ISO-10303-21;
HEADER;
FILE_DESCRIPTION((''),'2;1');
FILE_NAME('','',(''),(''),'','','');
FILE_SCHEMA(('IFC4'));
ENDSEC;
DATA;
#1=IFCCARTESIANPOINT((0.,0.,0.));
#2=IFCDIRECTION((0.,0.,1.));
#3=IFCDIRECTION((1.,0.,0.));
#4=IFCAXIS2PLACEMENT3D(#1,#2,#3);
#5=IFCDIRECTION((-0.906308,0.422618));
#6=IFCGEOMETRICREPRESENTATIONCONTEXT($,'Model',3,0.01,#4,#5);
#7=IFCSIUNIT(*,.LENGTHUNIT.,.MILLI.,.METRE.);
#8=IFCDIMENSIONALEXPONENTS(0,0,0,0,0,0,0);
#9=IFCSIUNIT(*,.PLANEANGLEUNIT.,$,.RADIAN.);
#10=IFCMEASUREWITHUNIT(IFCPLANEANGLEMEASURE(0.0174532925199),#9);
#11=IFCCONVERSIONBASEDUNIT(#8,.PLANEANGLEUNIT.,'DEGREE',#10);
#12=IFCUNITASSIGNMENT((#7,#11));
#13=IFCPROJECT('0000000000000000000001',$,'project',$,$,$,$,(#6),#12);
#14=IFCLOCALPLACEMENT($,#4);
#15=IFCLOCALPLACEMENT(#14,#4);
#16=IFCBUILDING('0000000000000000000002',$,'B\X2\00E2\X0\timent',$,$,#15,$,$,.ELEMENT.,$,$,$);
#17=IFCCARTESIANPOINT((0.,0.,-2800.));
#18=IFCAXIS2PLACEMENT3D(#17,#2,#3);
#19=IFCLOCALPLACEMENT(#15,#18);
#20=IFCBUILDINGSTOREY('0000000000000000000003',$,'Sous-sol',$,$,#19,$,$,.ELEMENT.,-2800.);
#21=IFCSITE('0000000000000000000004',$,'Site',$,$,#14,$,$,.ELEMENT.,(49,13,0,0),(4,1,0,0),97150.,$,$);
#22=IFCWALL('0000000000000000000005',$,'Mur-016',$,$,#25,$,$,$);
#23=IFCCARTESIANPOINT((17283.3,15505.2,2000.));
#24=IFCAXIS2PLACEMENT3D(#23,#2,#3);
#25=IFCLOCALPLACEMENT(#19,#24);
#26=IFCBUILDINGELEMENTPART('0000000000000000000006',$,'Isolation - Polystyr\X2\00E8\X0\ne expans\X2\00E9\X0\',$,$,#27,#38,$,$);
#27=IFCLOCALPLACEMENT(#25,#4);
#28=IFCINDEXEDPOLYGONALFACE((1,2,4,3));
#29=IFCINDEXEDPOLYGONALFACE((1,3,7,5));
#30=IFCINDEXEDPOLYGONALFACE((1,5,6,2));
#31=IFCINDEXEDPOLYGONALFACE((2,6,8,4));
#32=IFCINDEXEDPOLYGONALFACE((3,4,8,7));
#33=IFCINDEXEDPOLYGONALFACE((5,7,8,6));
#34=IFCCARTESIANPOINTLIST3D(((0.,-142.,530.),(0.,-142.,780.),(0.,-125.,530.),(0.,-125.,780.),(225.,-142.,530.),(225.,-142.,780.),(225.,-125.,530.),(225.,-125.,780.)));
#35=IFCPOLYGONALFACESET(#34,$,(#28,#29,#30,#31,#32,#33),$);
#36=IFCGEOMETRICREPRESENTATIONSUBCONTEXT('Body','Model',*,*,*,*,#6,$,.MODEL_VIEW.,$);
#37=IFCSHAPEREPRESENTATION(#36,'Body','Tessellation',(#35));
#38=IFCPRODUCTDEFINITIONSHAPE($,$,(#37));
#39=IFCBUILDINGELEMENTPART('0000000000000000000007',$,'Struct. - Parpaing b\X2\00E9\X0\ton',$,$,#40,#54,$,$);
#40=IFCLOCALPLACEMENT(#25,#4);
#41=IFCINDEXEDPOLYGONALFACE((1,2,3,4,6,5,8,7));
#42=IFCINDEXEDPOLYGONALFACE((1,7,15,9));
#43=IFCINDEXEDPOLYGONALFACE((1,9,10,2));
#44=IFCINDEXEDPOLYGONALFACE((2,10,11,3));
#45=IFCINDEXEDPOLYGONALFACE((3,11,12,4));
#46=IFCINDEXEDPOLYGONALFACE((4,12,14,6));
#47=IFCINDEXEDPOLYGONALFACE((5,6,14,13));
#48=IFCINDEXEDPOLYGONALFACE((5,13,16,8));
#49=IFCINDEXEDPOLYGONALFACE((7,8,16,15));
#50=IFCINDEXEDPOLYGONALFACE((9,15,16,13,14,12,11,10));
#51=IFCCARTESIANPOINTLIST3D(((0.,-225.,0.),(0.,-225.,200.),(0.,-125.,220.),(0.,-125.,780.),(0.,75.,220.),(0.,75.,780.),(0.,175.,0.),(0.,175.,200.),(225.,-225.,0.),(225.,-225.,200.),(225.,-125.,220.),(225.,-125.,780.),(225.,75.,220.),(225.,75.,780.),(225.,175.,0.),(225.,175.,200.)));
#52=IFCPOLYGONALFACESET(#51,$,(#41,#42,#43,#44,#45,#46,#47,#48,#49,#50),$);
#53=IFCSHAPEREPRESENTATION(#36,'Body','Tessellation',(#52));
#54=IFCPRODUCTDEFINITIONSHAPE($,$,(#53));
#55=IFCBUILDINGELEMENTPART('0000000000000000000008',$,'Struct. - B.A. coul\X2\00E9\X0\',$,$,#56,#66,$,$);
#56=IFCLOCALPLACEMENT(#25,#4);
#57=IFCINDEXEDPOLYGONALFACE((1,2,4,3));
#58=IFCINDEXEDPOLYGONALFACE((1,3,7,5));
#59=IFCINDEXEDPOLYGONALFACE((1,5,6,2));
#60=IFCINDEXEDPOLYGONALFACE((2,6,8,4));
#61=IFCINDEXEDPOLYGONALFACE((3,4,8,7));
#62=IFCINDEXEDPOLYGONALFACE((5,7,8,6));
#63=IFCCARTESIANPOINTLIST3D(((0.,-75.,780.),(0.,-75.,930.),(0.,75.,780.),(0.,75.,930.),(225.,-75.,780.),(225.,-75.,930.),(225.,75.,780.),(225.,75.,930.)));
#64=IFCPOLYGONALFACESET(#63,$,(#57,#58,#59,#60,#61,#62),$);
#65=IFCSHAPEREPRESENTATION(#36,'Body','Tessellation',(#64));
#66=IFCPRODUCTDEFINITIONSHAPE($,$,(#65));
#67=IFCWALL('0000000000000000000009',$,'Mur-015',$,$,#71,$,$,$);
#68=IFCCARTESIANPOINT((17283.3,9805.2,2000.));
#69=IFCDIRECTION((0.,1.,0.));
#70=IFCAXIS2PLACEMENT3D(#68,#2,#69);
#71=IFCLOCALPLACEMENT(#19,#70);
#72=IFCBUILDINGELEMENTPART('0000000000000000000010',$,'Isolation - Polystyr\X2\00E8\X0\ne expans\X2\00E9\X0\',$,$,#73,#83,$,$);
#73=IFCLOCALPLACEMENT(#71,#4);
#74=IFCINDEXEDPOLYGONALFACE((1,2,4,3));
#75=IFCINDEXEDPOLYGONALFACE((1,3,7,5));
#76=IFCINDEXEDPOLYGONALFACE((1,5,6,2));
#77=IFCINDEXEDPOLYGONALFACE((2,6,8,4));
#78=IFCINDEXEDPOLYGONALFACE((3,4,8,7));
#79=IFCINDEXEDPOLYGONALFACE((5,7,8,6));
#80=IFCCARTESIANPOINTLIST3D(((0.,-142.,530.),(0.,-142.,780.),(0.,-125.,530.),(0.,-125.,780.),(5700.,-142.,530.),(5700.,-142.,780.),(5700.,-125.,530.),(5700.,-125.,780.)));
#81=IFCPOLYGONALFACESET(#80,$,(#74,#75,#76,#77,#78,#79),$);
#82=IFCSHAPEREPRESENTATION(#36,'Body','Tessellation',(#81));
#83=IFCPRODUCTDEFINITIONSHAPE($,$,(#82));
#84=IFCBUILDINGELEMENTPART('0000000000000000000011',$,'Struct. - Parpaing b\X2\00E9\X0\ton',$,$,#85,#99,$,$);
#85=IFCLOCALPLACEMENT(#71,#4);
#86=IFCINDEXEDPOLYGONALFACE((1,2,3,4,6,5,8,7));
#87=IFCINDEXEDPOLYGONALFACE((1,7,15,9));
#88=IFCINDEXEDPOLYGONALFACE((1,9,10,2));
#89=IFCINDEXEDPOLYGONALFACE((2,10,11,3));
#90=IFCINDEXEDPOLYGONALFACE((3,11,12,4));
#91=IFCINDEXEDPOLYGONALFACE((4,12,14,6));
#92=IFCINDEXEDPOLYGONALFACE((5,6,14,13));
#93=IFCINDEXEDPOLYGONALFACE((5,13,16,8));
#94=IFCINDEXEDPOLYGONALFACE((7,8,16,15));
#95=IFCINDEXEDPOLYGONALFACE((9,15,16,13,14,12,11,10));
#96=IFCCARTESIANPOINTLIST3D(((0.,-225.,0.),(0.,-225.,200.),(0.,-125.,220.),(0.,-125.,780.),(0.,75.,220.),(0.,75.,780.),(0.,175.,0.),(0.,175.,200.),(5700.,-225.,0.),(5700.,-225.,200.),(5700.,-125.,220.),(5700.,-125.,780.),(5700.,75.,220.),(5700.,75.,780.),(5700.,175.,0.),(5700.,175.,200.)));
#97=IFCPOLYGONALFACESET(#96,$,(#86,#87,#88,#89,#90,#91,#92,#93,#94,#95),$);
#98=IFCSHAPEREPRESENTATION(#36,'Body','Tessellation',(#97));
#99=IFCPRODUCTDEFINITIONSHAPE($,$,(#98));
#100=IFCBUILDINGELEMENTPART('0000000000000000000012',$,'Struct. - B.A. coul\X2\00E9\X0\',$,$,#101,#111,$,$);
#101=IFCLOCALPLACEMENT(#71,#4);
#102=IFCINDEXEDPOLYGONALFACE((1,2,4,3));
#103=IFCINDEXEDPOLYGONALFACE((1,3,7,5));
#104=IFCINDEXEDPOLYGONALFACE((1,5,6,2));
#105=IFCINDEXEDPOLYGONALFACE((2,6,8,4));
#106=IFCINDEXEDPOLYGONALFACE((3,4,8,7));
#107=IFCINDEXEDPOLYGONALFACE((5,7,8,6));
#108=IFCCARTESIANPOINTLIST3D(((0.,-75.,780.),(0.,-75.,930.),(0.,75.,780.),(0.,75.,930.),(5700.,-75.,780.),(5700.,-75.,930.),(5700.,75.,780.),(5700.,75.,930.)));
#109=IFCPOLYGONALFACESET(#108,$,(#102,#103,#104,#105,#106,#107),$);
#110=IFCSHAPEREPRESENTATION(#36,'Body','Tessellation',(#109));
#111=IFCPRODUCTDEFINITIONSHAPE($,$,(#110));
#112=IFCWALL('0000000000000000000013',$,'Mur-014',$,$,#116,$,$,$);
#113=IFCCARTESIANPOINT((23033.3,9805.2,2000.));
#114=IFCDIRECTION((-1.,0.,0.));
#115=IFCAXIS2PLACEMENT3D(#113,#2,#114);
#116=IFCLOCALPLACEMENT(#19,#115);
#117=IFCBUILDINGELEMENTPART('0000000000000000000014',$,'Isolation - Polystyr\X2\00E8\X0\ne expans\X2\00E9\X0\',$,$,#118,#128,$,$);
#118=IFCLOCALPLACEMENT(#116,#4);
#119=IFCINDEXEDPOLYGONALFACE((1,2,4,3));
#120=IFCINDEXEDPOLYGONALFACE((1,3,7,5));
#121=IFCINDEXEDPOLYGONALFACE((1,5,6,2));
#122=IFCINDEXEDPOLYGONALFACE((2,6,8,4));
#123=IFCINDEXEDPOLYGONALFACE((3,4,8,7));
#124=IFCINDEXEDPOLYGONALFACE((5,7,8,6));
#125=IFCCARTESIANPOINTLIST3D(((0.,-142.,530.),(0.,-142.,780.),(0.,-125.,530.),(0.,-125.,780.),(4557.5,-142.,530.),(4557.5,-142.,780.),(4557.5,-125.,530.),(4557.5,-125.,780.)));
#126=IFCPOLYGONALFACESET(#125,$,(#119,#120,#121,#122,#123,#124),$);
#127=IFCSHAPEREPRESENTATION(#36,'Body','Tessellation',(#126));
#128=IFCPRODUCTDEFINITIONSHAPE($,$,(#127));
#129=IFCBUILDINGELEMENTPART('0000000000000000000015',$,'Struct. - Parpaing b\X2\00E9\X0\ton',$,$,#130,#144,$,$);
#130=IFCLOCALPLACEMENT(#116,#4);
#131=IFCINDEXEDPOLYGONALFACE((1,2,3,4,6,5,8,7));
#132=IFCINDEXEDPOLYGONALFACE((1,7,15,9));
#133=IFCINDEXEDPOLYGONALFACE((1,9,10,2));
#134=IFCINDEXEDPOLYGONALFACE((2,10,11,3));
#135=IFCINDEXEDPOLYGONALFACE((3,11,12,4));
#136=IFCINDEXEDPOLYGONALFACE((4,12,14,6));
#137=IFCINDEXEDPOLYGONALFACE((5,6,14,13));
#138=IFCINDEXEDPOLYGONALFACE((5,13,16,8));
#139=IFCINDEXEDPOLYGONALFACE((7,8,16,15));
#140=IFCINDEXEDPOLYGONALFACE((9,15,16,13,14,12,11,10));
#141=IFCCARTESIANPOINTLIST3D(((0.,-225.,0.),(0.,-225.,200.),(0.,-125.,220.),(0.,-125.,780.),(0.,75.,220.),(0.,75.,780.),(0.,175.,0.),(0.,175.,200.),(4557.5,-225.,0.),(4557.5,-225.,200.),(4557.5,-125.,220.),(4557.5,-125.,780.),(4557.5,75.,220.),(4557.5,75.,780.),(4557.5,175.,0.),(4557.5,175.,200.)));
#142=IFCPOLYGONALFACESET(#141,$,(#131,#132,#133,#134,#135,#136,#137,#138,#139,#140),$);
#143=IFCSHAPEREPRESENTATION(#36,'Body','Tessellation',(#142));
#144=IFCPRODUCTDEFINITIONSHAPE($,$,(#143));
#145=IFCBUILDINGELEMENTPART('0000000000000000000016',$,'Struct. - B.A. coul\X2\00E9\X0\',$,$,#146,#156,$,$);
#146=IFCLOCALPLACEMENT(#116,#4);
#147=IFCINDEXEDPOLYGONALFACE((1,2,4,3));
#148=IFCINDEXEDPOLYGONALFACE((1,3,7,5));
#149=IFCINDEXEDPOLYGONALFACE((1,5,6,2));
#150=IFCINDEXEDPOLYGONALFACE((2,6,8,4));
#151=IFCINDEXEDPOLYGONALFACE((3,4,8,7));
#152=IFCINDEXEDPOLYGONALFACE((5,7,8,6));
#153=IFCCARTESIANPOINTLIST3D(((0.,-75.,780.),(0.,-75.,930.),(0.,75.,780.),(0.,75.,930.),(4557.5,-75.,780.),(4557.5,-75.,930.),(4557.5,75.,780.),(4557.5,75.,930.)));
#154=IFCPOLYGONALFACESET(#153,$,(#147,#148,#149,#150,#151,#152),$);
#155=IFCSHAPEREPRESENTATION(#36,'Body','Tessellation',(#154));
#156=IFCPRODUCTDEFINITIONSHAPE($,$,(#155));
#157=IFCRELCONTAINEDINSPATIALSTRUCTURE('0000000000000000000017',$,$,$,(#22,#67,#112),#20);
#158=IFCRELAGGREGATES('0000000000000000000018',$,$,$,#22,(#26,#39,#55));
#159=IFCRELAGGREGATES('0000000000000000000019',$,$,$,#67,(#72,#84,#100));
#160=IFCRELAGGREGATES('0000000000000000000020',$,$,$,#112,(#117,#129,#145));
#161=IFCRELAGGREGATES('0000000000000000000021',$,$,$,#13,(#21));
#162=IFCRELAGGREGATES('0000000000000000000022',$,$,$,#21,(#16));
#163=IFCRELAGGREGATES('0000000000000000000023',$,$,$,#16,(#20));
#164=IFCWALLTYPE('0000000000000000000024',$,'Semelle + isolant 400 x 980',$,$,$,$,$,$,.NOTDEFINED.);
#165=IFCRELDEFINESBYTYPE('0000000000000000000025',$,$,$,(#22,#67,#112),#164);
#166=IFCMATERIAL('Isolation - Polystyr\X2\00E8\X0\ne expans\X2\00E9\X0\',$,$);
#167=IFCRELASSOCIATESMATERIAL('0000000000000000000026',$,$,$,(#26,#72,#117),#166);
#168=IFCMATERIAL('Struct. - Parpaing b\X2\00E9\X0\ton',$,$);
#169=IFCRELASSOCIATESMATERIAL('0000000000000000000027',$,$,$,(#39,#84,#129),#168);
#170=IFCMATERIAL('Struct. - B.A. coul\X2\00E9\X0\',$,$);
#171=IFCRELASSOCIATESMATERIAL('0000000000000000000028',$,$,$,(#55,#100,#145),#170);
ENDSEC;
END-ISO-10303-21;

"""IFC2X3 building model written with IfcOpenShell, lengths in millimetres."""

from ifc_helpers import new_model, entity, si_unit, converted_unit, direction, frame, origin_with_axes, place, context, subcontext, project, spatial, polyline, outline, extrude, material, type_object, element, aggregate, save


model = new_model("IFC2X3")

# Units and contexts
model_context = context("Model", 3, precision=0.01, world=origin_with_axes(), true_north=direction((-0.906308, 0.422618)))
body_context = subcontext(model_context, "Body", "Model", "MODEL_VIEW")
ifc_project = project(units=[si_unit("LENGTHUNIT", "METRE", prefix="MILLI"), converted_unit("PLANEANGLEUNIT", "DEGREE", entity("IfcPlaneAngleMeasure", 0.0174532925199), si_unit("PLANEANGLEUNIT", "RADIAN"), dimensions=[0, 0, 0, 0, 0, 0, 0])], contexts=[model_context])

# Site, building, storey
site_placement = place(None, origin_with_axes())
site = spatial("IfcSite", under=ifc_project, at=site_placement, Name="Site", CompositionType="ELEMENT", RefLatitude=(49, 13, 0, 0), RefLongitude=(4, 1, 0, 0), RefElevation=97150.0)
building_placement = place(site_placement, origin_with_axes())
building = spatial("IfcBuilding", under=site, at=building_placement, Name="Bâtiment", CompositionType="ELEMENT")
storey_placement = place(building_placement, frame((0.0, 0.0, -2800.0), z_axis=(0.0, 0.0, 1.0), x_axis=(1.0, 0.0, 0.0)))
storey = spatial("IfcBuildingStorey", under=building, at=storey_placement, Name="Sous-sol", CompositionType="ELEMENT", Elevation=-2800.0)

# Walls, building element parts
ifc_material_1 = material(Name="Struct. - Parpaing béton")
ifc_material_2 = material(Name="Isolation - Polystyrène expansé")
wall_type_1 = type_object("IfcWallType", Name="Semelle + isolant 400 x 980", PredefinedType="NOTDEFINED")
ifc_material_3 = material(Name="Struct. - B.A. coulé")
wall_1_placement = place(storey_placement, frame((17283.3, 15505.2, 2000.0), z_axis=(0.0, 0.0, 1.0), x_axis=(1.0, 0.0, 0.0)))
wall_1 = element("IfcWall", 1, at=wall_1_placement, inside=storey, type_object=wall_type_1, Name="Mur-016")
building_element_part_1_placement = place(wall_1_placement, origin_with_axes())
building_element_part_1 = element("IfcBuildingElementPart", 2, at=building_element_part_1_placement, material=ifc_material_2, Name="Isolation - Polystyrène expansé", context=body_context, shape_type="SweptSolid", body=[
    extrude(outline(polyline([(125.0, 780.0), (125.0, 530.0), (142.0, 530.0), (142.0, 780.0), (125.0, 780.0)])), frame((0.0, 0.0, 0.0), z_axis=(-1.0, 0.0, 0.0), x_axis=(0.0, -1.0, 0.0)), (0.0, 0.0, -1.0), 225.0),
])
building_element_part_2_placement = place(wall_1_placement, origin_with_axes())
building_element_part_2 = element("IfcBuildingElementPart", 3, at=building_element_part_2_placement, material=ifc_material_1, Name="Struct. - Parpaing béton", context=body_context, shape_type="SweptSolid", body=[
    extrude(outline(polyline([(-75.0, 220.0), (-175.0, 200.0), (-175.0, 0.0), (225.0, 0.0), (225.0, 200.0), (125.0, 220.0), (125.0, 780.0), (-75.0, 780.0), (-75.0, 220.0)])), frame((0.0, 0.0, 0.0), z_axis=(-1.0, 0.0, 0.0), x_axis=(0.0, -1.0, 0.0)), (0.0, 0.0, -1.0), 225.0),
])
building_element_part_3_placement = place(wall_1_placement, origin_with_axes())
building_element_part_3 = element("IfcBuildingElementPart", 4, at=building_element_part_3_placement, material=ifc_material_3, Name="Struct. - B.A. coulé", context=body_context, shape_type="SweptSolid", body=[
    extrude(outline(polyline([(75.0, 780.0), (75.0, 930.0), (-75.0, 930.0), (-75.0, 780.0), (75.0, 780.0)])), frame((0.0, 0.0, 0.0), z_axis=(-1.0, 0.0, 0.0), x_axis=(0.0, -1.0, 0.0)), (0.0, 0.0, -1.0), 225.0),
])
aggregate(wall_1, [building_element_part_1, building_element_part_2, building_element_part_3])
wall_2_placement = place(storey_placement, frame((17283.3, 9805.2, 2000.0), z_axis=(0.0, 0.0, 1.0), x_axis=(0.0, 1.0, 0.0)))
wall_2 = element("IfcWall", 5, at=wall_2_placement, inside=storey, type_object=wall_type_1, Name="Mur-015")
building_element_part_4_placement = place(wall_2_placement, origin_with_axes())
building_element_part_4 = element("IfcBuildingElementPart", 6, at=building_element_part_4_placement, material=ifc_material_2, Name="Isolation - Polystyrène expansé", context=body_context, shape_type="SweptSolid", body=[
    extrude(outline(polyline([(125.0, 780.0), (125.0, 530.0), (142.0, 530.0), (142.0, 780.0), (125.0, 780.0)])), frame((0.0, 0.0, 0.0), z_axis=(-1.0, 0.0, 0.0), x_axis=(0.0, -1.0, 0.0)), (0.0, 0.0, -1.0), 5700.0),
])
building_element_part_5_placement = place(wall_2_placement, origin_with_axes())
building_element_part_5 = element("IfcBuildingElementPart", 7, at=building_element_part_5_placement, material=ifc_material_1, Name="Struct. - Parpaing béton", context=body_context, shape_type="SweptSolid", body=[
    extrude(outline(polyline([(-75.0, 220.0), (-175.0, 200.0), (-175.0, 0.0), (225.0, 0.0), (225.0, 200.0), (125.0, 220.0), (125.0, 780.0), (-75.0, 780.0), (-75.0, 220.0)])), frame((0.0, 0.0, 0.0), z_axis=(-1.0, 0.0, 0.0), x_axis=(0.0, -1.0, 0.0)), (0.0, 0.0, -1.0), 5700.0),
])
building_element_part_6_placement = place(wall_2_placement, origin_with_axes())
building_element_part_6 = element("IfcBuildingElementPart", 8, at=building_element_part_6_placement, material=ifc_material_3, Name="Struct. - B.A. coulé", context=body_context, shape_type="SweptSolid", body=[
    extrude(outline(polyline([(75.0, 780.0), (75.0, 930.0), (-75.0, 930.0), (-75.0, 780.0), (75.0, 780.0)])), frame((0.0, 0.0, 0.0), z_axis=(-1.0, 0.0, 0.0), x_axis=(0.0, -1.0, 0.0)), (0.0, 0.0, -1.0), 5700.0),
])
aggregate(wall_2, [building_element_part_4, building_element_part_5, building_element_part_6])
wall_3_placement = place(storey_placement, frame((23033.3, 9805.2, 2000.0), z_axis=(0.0, 0.0, 1.0), x_axis=(-1.0, 0.0, 0.0)))
wall_3 = element("IfcWall", 9, at=wall_3_placement, inside=storey, type_object=wall_type_1, Name="Mur-014")
building_element_part_7_placement = place(wall_3_placement, origin_with_axes())
building_element_part_7 = element("IfcBuildingElementPart", 10, at=building_element_part_7_placement, material=ifc_material_2, Name="Isolation - Polystyrène expansé", context=body_context, shape_type="SweptSolid", body=[
    extrude(outline(polyline([(125.0, 780.0), (125.0, 530.0), (142.0, 530.0), (142.0, 780.0), (125.0, 780.0)])), frame((0.0, 0.0, 0.0), z_axis=(-1.0, 0.0, 0.0), x_axis=(0.0, -1.0, 0.0)), (0.0, 0.0, -1.0), 4557.5),
])
building_element_part_8_placement = place(wall_3_placement, origin_with_axes())
building_element_part_8 = element("IfcBuildingElementPart", 11, at=building_element_part_8_placement, material=ifc_material_1, Name="Struct. - Parpaing béton", context=body_context, shape_type="SweptSolid", body=[
    extrude(outline(polyline([(-75.0, 220.0), (-175.0, 200.0), (-175.0, 0.0), (225.0, 0.0), (225.0, 200.0), (125.0, 220.0), (125.0, 780.0), (-75.0, 780.0), (-75.0, 220.0)])), frame((0.0, 0.0, 0.0), z_axis=(-1.0, 0.0, 0.0), x_axis=(0.0, -1.0, 0.0)), (0.0, 0.0, -1.0), 4557.5),
])
building_element_part_9_placement = place(wall_3_placement, origin_with_axes())
building_element_part_9 = element("IfcBuildingElementPart", 12, at=building_element_part_9_placement, material=ifc_material_3, Name="Struct. - B.A. coulé", context=body_context, shape_type="SweptSolid", body=[
    extrude(outline(polyline([(75.0, 780.0), (75.0, 930.0), (-75.0, 930.0), (-75.0, 780.0), (75.0, 780.0)])), frame((0.0, 0.0, 0.0), z_axis=(-1.0, 0.0, 0.0), x_axis=(0.0, -1.0, 0.0)), (0.0, 0.0, -1.0), 4557.5),
])
aggregate(wall_3, [building_element_part_7, building_element_part_8, building_element_part_9])

save(model, "model.ifc")
